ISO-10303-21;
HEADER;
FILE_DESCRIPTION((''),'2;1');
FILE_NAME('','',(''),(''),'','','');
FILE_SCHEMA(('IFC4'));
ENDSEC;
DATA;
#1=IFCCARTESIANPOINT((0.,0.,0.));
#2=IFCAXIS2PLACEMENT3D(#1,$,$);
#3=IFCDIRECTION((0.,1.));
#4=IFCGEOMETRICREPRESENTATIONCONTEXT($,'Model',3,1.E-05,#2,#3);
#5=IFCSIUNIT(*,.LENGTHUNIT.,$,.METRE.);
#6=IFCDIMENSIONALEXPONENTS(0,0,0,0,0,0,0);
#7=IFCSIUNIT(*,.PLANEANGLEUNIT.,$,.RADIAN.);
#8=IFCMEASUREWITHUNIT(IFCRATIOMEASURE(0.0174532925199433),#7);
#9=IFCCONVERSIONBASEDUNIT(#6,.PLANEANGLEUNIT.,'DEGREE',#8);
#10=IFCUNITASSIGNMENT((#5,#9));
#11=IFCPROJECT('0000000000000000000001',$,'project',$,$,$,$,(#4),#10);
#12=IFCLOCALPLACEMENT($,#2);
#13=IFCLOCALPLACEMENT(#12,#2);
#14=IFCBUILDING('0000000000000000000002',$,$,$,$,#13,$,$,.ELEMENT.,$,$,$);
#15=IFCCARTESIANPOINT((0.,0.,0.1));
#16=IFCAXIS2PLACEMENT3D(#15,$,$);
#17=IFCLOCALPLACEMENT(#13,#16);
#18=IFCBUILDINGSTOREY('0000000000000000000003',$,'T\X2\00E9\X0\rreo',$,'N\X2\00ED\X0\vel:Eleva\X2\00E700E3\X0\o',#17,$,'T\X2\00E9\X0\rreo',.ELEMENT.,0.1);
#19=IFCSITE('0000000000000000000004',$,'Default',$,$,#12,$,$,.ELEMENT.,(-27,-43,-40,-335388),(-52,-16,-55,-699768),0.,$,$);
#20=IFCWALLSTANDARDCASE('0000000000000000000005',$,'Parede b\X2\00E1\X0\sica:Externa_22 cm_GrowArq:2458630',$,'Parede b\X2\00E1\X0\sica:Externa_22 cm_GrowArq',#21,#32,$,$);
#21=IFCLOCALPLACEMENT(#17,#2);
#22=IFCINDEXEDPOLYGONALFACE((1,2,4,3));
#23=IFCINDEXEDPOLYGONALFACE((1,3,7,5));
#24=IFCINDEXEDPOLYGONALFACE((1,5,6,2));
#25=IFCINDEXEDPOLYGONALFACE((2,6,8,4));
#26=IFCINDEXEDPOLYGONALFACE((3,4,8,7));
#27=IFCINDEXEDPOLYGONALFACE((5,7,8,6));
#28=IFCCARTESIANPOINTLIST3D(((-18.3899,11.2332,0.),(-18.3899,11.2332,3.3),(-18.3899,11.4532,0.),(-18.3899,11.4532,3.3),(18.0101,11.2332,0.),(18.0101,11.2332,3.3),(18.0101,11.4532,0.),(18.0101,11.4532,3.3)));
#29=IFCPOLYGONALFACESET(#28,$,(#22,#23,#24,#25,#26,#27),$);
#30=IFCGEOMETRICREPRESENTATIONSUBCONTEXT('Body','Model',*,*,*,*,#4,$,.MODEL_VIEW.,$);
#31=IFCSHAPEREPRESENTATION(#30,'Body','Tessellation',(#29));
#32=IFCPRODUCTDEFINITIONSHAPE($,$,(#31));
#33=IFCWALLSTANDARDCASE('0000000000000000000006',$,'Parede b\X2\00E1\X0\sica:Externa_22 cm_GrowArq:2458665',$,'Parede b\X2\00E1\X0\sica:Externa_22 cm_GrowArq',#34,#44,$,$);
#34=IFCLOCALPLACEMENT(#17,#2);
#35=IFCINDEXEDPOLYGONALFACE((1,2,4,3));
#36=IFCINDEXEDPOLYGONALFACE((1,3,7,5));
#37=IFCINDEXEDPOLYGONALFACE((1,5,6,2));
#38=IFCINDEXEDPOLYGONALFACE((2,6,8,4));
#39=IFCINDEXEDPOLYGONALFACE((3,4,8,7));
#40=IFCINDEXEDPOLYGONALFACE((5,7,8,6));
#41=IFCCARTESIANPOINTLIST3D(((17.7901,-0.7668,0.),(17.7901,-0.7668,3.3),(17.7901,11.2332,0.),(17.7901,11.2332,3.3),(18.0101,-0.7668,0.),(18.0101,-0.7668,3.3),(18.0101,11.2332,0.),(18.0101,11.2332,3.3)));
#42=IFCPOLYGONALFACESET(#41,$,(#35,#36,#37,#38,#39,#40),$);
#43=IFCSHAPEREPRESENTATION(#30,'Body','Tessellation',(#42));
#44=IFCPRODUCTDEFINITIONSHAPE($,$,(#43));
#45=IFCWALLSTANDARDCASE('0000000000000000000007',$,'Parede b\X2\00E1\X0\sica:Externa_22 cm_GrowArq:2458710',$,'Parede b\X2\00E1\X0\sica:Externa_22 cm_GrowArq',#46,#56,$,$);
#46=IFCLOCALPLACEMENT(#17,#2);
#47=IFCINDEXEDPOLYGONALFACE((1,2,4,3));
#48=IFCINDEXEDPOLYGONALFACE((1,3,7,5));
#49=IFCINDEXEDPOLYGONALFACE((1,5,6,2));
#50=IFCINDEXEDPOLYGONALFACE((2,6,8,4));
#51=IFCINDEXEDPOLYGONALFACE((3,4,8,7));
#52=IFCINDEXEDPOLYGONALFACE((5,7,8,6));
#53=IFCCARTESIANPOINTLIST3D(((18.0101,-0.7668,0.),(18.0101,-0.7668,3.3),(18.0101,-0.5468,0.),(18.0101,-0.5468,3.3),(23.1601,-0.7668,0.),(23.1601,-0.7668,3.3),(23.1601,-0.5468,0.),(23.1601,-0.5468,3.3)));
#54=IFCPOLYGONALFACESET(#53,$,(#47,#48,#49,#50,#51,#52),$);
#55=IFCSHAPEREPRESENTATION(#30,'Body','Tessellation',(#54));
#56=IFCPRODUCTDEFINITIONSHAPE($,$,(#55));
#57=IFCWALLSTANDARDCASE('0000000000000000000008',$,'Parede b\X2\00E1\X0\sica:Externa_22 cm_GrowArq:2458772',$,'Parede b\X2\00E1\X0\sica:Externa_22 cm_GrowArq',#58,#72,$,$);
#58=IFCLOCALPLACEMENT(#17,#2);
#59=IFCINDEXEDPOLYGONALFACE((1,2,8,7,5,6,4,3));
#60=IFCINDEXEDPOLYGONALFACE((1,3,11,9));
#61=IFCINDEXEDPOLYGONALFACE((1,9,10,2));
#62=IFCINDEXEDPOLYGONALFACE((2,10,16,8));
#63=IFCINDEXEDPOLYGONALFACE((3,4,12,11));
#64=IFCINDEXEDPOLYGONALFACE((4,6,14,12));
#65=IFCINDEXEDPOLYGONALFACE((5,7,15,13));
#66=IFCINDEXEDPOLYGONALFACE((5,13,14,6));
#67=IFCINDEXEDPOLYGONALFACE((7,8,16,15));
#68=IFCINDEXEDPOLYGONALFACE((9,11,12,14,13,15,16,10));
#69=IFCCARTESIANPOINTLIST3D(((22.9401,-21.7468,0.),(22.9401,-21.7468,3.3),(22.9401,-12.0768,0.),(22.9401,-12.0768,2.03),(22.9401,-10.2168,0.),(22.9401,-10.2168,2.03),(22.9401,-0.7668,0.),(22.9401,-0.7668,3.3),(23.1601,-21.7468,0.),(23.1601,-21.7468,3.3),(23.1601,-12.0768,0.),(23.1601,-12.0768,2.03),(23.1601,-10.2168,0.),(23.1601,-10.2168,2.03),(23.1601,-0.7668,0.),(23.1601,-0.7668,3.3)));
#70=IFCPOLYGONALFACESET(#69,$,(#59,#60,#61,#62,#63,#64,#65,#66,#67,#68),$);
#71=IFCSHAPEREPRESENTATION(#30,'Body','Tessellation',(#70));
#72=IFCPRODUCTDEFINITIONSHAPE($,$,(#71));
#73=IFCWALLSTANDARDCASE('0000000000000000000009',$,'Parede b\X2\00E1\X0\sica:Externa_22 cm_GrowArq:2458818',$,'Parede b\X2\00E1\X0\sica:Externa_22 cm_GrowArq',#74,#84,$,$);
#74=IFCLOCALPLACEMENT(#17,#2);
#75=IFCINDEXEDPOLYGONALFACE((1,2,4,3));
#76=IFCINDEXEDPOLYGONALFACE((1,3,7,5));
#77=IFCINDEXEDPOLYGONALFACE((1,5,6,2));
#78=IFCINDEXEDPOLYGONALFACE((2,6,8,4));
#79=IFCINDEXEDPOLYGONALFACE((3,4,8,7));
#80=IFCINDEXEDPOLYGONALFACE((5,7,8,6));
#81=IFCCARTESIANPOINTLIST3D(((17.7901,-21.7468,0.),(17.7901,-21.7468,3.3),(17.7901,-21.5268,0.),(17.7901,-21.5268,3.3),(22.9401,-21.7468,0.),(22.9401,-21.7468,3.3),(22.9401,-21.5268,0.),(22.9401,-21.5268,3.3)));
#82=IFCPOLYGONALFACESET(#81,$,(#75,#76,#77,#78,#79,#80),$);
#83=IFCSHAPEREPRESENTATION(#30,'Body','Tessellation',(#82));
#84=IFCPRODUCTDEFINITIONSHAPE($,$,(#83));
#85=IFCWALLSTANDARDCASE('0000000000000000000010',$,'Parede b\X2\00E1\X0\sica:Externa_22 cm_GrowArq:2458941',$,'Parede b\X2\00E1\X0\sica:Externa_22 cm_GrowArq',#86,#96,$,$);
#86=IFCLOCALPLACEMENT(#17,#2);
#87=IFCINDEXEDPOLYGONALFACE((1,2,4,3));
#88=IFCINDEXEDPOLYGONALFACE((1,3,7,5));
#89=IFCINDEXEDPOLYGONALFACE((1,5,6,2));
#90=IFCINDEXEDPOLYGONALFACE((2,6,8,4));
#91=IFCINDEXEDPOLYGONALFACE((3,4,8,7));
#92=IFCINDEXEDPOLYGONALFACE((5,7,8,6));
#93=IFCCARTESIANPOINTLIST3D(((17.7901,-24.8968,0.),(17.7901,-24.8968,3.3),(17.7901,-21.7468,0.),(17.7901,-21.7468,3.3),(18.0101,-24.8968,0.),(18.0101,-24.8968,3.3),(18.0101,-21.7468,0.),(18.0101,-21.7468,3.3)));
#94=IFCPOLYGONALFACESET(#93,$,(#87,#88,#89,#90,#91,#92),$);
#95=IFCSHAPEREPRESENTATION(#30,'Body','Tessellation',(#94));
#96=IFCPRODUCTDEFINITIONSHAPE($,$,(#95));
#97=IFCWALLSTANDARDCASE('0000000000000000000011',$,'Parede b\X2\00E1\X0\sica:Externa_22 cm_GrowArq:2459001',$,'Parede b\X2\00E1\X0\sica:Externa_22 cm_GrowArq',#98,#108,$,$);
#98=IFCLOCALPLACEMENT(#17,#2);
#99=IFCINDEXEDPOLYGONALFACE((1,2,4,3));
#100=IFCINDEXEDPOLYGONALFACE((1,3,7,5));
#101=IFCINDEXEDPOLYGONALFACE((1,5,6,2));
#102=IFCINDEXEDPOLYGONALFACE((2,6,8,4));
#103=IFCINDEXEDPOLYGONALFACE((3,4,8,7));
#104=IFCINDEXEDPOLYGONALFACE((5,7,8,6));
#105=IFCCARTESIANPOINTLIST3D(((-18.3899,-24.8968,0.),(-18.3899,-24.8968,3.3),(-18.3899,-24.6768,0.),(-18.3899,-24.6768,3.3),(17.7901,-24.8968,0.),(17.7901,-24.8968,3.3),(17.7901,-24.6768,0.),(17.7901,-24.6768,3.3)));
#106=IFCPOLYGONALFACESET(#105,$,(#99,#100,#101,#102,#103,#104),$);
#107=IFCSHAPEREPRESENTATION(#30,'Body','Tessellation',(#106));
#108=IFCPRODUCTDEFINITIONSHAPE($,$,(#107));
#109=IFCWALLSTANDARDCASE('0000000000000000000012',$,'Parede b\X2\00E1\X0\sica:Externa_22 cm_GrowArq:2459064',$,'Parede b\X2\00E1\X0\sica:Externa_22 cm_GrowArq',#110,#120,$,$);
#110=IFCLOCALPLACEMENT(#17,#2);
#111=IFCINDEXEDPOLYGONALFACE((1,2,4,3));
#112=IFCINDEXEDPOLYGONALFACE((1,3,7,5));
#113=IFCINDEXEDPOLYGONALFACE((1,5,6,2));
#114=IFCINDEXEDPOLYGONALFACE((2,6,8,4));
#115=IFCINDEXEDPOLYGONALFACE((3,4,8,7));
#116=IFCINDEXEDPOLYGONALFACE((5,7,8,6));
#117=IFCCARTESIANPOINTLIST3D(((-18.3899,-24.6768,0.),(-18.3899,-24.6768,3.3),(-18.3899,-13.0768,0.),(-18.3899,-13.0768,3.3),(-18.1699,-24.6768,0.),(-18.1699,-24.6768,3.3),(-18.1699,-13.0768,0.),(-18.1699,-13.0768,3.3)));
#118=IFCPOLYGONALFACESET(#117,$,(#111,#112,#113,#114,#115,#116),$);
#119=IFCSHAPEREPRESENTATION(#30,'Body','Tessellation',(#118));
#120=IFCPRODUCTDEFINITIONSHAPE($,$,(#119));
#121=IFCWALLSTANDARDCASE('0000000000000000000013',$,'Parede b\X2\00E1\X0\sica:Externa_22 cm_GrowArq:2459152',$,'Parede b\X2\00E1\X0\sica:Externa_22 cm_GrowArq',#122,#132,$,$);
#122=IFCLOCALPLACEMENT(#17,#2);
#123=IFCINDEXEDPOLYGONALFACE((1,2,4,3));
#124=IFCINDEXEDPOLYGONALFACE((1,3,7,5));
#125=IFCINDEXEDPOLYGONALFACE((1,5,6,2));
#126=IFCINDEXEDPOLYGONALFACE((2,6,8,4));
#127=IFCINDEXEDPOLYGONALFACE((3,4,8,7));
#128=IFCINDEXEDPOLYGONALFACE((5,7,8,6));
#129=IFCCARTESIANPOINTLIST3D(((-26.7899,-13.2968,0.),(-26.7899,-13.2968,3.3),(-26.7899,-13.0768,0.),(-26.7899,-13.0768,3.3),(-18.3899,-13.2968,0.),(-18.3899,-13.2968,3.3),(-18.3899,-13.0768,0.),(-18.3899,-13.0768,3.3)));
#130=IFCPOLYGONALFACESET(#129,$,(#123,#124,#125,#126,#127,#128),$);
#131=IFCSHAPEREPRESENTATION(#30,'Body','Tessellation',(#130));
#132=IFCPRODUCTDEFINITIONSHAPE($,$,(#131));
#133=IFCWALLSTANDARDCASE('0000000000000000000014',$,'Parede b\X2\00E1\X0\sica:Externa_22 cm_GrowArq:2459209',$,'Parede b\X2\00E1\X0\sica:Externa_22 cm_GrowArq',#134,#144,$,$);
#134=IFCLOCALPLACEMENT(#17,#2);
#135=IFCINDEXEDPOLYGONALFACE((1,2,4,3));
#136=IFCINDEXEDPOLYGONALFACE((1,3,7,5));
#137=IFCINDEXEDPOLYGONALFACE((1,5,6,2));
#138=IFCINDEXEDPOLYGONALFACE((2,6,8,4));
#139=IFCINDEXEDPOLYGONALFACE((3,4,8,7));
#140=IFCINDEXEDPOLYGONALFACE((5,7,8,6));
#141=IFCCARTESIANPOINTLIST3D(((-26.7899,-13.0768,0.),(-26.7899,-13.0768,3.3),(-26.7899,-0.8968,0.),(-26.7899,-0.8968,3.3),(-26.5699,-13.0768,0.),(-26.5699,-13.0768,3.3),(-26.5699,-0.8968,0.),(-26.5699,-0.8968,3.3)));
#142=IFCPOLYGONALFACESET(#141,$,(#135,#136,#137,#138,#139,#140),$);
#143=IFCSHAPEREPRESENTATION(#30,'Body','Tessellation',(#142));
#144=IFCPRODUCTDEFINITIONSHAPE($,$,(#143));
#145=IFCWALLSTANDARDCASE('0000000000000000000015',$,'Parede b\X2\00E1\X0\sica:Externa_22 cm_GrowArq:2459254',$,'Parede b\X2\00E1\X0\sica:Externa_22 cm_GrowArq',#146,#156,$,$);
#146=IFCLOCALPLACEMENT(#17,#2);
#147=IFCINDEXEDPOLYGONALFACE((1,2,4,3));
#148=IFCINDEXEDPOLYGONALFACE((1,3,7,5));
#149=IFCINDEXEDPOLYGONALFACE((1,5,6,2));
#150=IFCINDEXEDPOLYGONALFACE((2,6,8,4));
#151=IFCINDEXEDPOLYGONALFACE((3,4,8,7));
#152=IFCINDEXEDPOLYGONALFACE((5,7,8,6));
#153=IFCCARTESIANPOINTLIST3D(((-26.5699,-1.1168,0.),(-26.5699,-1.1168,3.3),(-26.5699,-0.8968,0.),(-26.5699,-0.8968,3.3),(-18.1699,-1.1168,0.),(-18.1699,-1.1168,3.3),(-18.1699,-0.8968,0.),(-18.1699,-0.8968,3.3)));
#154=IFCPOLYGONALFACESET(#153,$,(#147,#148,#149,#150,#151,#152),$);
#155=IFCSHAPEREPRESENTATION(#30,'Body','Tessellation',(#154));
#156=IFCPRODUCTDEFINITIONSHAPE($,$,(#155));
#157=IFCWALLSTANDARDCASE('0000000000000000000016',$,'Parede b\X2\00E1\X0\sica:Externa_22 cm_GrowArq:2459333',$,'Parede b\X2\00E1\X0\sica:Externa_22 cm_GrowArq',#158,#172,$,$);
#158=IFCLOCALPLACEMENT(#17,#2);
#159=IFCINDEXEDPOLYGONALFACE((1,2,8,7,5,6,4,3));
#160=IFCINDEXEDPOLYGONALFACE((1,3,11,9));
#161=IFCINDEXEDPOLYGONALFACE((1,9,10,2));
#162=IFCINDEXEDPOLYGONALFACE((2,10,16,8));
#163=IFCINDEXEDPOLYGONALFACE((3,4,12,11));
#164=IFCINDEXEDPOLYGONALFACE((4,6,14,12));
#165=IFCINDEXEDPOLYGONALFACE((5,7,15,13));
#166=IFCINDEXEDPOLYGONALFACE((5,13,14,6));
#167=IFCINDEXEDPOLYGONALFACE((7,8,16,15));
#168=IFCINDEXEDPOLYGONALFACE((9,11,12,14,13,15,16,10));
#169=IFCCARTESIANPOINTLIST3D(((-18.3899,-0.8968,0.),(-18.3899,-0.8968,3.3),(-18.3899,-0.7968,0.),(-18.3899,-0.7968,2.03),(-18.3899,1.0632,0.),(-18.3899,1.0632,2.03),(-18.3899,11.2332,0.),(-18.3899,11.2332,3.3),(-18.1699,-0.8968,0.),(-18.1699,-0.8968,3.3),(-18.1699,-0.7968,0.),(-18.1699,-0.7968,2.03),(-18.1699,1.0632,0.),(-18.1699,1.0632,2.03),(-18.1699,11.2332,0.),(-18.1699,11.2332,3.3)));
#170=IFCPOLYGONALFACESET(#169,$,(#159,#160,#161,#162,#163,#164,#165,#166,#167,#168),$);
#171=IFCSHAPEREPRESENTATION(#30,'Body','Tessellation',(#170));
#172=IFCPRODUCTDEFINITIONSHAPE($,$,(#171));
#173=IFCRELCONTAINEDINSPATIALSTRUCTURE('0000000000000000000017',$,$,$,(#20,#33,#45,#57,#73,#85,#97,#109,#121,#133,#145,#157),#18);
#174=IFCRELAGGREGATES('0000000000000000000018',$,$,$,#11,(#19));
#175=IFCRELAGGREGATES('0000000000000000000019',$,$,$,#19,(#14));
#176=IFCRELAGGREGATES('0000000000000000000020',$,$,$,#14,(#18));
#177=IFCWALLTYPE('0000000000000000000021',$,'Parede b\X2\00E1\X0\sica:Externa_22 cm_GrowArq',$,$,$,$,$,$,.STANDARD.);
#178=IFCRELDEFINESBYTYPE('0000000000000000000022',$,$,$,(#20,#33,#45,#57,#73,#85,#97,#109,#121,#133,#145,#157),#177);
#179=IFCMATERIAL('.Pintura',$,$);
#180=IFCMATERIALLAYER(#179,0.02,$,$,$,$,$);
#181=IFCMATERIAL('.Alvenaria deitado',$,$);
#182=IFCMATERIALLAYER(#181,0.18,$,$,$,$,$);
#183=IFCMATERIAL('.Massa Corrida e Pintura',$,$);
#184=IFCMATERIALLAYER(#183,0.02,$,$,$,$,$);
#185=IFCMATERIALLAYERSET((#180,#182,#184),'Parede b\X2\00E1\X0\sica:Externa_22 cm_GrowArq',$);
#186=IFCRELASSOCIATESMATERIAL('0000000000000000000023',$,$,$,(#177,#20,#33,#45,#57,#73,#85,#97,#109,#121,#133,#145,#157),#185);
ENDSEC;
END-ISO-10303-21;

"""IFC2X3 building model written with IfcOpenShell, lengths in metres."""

from ifc_helpers import new_model, entity, si_unit, converted_unit, direction, frame, frame_2d, origin, place, context, subcontext, project, spatial, rectangle, extrude, material, layer, layer_set, layer_usage, type_object, element, save


model = new_model("IFC2X3")

# Units and contexts
model_context = context("Model", 3, precision=1e-05, world=origin(), true_north=direction((0.0, 1.0)))
body_context = subcontext(model_context, "Body", "Model", "MODEL_VIEW")
ifc_project = project(units=[si_unit("LENGTHUNIT", "METRE"), converted_unit("PLANEANGLEUNIT", "DEGREE", entity("IfcRatioMeasure", 0.0174532925199433), si_unit("PLANEANGLEUNIT", "RADIAN"), dimensions=[0, 0, 0, 0, 0, 0, 0])], contexts=[model_context])

# Site, building, storey
site_placement = place(None, origin())
site = spatial("IfcSite", under=ifc_project, at=site_placement, Name="Default", CompositionType="ELEMENT", RefLatitude=(-27, -43, -40, -335388), RefLongitude=(-52, -16, -55, -699768), RefElevation=0.0)
building_placement = place(site_placement, origin())
building = spatial("IfcBuilding", under=site, at=building_placement, CompositionType="ELEMENT")
storey_placement = place(building_placement, frame((0.0, 0.0, 0.1)))
storey = spatial("IfcBuildingStorey", under=building, at=storey_placement, Name="Térreo", ObjectType="Nível:Elevação", LongName="Térreo", CompositionType="ELEMENT", Elevation=0.1)

# Walls
ifc_material_1 = material(Name=".Pintura")
ifc_layer_1 = layer(ifc_material_1, 0.02)
ifc_material_2 = material(Name=".Alvenaria deitado")
ifc_layer_2 = layer(ifc_material_2, 0.18)
ifc_material_3 = material(Name=".Massa Corrida e Pintura")
ifc_layer_3 = layer(ifc_material_3, 0.02)
ifc_layer_set_1 = layer_set([ifc_layer_1, ifc_layer_2, ifc_layer_3], Name="Parede básica:Externa_22 cm_GrowArq")
ifc_layer_usage_1 = layer_usage(ifc_layer_set_1, "AXIS2", "NEGATIVE", 0.11)
wall_type = type_object("IfcWallType", Name="Parede básica:Externa_22 cm_GrowArq", PredefinedType="STANDARD", material=ifc_layer_set_1)
wall_1_placement = place(storey_placement, frame((-18.3899, 11.3432, 0.0)))
element("IfcWallStandardCase", 1, at=wall_1_placement, inside=storey, type_object=wall_type, material=ifc_layer_usage_1, Name="Parede básica:Externa_22 cm_GrowArq:2458630", ObjectType="Parede básica:Externa_22 cm_GrowArq", context=body_context, shape_type="SweptSolid", body=[
    extrude(rectangle(XDim=36.4, YDim=0.22, at=frame_2d((18.2, 0.0), x_axis=(-1.0, 0.0))), origin(), (0.0, 0.0, 1.0), 3.3),
])
ifc_layer_usage_2 = layer_usage(ifc_layer_set_1, "AXIS2", "NEGATIVE", 0.11)
wall_2_placement = place(storey_placement, frame((17.9001, 11.2332, 0.0), z_axis=(0.0, 0.0, 1.0), x_axis=(0.0, -1.0, 0.0)))
element("IfcWallStandardCase", 2, at=wall_2_placement, inside=storey, type_object=wall_type, material=ifc_layer_usage_2, Name="Parede básica:Externa_22 cm_GrowArq:2458665", ObjectType="Parede básica:Externa_22 cm_GrowArq", context=body_context, shape_type="SweptSolid", body=[
    extrude(rectangle(XDim=12.0, YDim=0.22, at=frame_2d((6.0, 0.0), x_axis=(-1.0, 0.0))), origin(), (0.0, 0.0, 1.0), 3.3),
])
ifc_layer_usage_3 = layer_usage(ifc_layer_set_1, "AXIS2", "NEGATIVE", 0.11)
wall_3_placement = place(storey_placement, frame((18.0101, -0.6568, 0.0)))
element("IfcWallStandardCase", 3, at=wall_3_placement, inside=storey, type_object=wall_type, material=ifc_layer_usage_3, Name="Parede básica:Externa_22 cm_GrowArq:2458710", ObjectType="Parede básica:Externa_22 cm_GrowArq", context=body_context, shape_type="SweptSolid", body=[
    extrude(rectangle(XDim=5.15, YDim=0.22, at=frame_2d((2.575, 0.0), x_axis=(-1.0, 0.0))), origin(), (0.0, 0.0, 1.0), 3.3),
])

# Wall, opening
ifc_layer_usage_4 = layer_usage(ifc_layer_set_1, "AXIS2", "NEGATIVE", 0.11)
wall_4_placement = place(storey_placement, frame((23.0501, -0.7668, 0.0), z_axis=(0.0, 0.0, 1.0), x_axis=(0.0, -1.0, 0.0)))
wall_4 = element("IfcWallStandardCase", 4, at=wall_4_placement, inside=storey, type_object=wall_type, material=ifc_layer_usage_4, Name="Parede básica:Externa_22 cm_GrowArq:2458772", ObjectType="Parede básica:Externa_22 cm_GrowArq", context=body_context, shape_type="SweptSolid", body=[
    extrude(rectangle(XDim=20.98, YDim=0.22, at=frame_2d((10.49, 0.0), x_axis=(-1.0, 0.0))), origin(), (0.0, 0.0, 1.0), 3.3),
])
opening_1_placement = place(wall_4_placement, frame((9.45, -0.11, -0.1)))
element("IfcOpeningElement", 5, at=opening_1_placement, cuts=wall_4, ObjectType="Opening", context=body_context, shape_type="SweptSolid", body=[
    extrude(rectangle(XDim=2.13, YDim=1.86, at=frame_2d((1.065, 0.93), x_axis=(1.0, 0.0))), frame((0.0, 0.0, 0.0), z_axis=(0.0, 1.0, 0.0), x_axis=(0.0, 0.0, 1.0)), (0.0, 0.0, 1.0), 0.22),
])

# Walls
ifc_layer_usage_5 = layer_usage(ifc_layer_set_1, "AXIS2", "NEGATIVE", 0.11)
wall_5_placement = place(storey_placement, frame((22.9401, -21.6368, 0.0), z_axis=(0.0, 0.0, 1.0), x_axis=(-1.0, 0.0, 0.0)))
element("IfcWallStandardCase", 6, at=wall_5_placement, inside=storey, type_object=wall_type, material=ifc_layer_usage_5, Name="Parede básica:Externa_22 cm_GrowArq:2458818", ObjectType="Parede básica:Externa_22 cm_GrowArq", context=body_context, shape_type="SweptSolid", body=[
    extrude(rectangle(XDim=5.15, YDim=0.22, at=frame_2d((2.575, 0.0), x_axis=(-1.0, 0.0))), origin(), (0.0, 0.0, 1.0), 3.3),
])
ifc_layer_usage_6 = layer_usage(ifc_layer_set_1, "AXIS2", "NEGATIVE", 0.11)
wall_6_placement = place(storey_placement, frame((17.9001, -21.7468, 0.0), z_axis=(0.0, 0.0, 1.0), x_axis=(0.0, -1.0, 0.0)))
element("IfcWallStandardCase", 7, at=wall_6_placement, inside=storey, type_object=wall_type, material=ifc_layer_usage_6, Name="Parede básica:Externa_22 cm_GrowArq:2458941", ObjectType="Parede básica:Externa_22 cm_GrowArq", context=body_context, shape_type="SweptSolid", body=[
    extrude(rectangle(XDim=3.15, YDim=0.22, at=frame_2d((1.575, 0.0), x_axis=(-1.0, 0.0))), origin(), (0.0, 0.0, 1.0), 3.3),
])
ifc_layer_usage_7 = layer_usage(ifc_layer_set_1, "AXIS2", "NEGATIVE", 0.11)
wall_7_placement = place(storey_placement, frame((17.7901, -24.7868, 0.0), z_axis=(0.0, 0.0, 1.0), x_axis=(-1.0, 0.0, 0.0)))
element("IfcWallStandardCase", 8, at=wall_7_placement, inside=storey, type_object=wall_type, material=ifc_layer_usage_7, Name="Parede básica:Externa_22 cm_GrowArq:2459001", ObjectType="Parede básica:Externa_22 cm_GrowArq", context=body_context, shape_type="SweptSolid", body=[
    extrude(rectangle(XDim=36.18, YDim=0.22, at=frame_2d((18.09, 0.0), x_axis=(-1.0, 0.0))), origin(), (0.0, 0.0, 1.0), 3.3),
])
ifc_layer_usage_8 = layer_usage(ifc_layer_set_1, "AXIS2", "NEGATIVE", 0.11)
wall_8_placement = place(storey_placement, frame((-18.2799, -24.6768, 0.0), z_axis=(0.0, 0.0, 1.0), x_axis=(0.0, 1.0, 0.0)))
element("IfcWallStandardCase", 9, at=wall_8_placement, inside=storey, type_object=wall_type, material=ifc_layer_usage_8, Name="Parede básica:Externa_22 cm_GrowArq:2459064", ObjectType="Parede básica:Externa_22 cm_GrowArq", context=body_context, shape_type="SweptSolid", body=[
    extrude(rectangle(XDim=11.6, YDim=0.22, at=frame_2d((5.8, 0.0), x_axis=(-1.0, 0.0))), origin(), (0.0, 0.0, 1.0), 3.3),
])
ifc_layer_usage_9 = layer_usage(ifc_layer_set_1, "AXIS2", "NEGATIVE", 0.11)
wall_9_placement = place(storey_placement, frame((-18.3899, -13.1868, 0.0), z_axis=(0.0, 0.0, 1.0), x_axis=(-1.0, 0.0, 0.0)))
element("IfcWallStandardCase", 10, at=wall_9_placement, inside=storey, type_object=wall_type, material=ifc_layer_usage_9, Name="Parede básica:Externa_22 cm_GrowArq:2459152", ObjectType="Parede básica:Externa_22 cm_GrowArq", context=body_context, shape_type="SweptSolid", body=[
    extrude(rectangle(XDim=8.4, YDim=0.22, at=frame_2d((4.2, 0.0), x_axis=(-1.0, 0.0))), origin(), (0.0, 0.0, 1.0), 3.3),
])
ifc_layer_usage_10 = layer_usage(ifc_layer_set_1, "AXIS2", "NEGATIVE", 0.11)
wall_10_placement = place(storey_placement, frame((-26.6799, -13.0768, 0.0), z_axis=(0.0, 0.0, 1.0), x_axis=(0.0, 1.0, 0.0)))
element("IfcWallStandardCase", 11, at=wall_10_placement, inside=storey, type_object=wall_type, material=ifc_layer_usage_10, Name="Parede básica:Externa_22 cm_GrowArq:2459209", ObjectType="Parede básica:Externa_22 cm_GrowArq", context=body_context, shape_type="SweptSolid", body=[
    extrude(rectangle(XDim=12.18, YDim=0.22, at=frame_2d((6.09, 0.0), x_axis=(-1.0, 0.0))), origin(), (0.0, 0.0, 1.0), 3.3),
])
ifc_layer_usage_11 = layer_usage(ifc_layer_set_1, "AXIS2", "NEGATIVE", 0.11)
wall_11_placement = place(storey_placement, frame((-26.5699, -1.0068, 0.0)))
element("IfcWallStandardCase", 12, at=wall_11_placement, inside=storey, type_object=wall_type, material=ifc_layer_usage_11, Name="Parede básica:Externa_22 cm_GrowArq:2459254", ObjectType="Parede básica:Externa_22 cm_GrowArq", context=body_context, shape_type="SweptSolid", body=[
    extrude(rectangle(XDim=8.4, YDim=0.22, at=frame_2d((4.2, 0.0), x_axis=(-1.0, 0.0))), origin(), (0.0, 0.0, 1.0), 3.3),
])

# Wall, opening
ifc_layer_usage_12 = layer_usage(ifc_layer_set_1, "AXIS2", "NEGATIVE", 0.11)
wall_12_placement = place(storey_placement, frame((-18.2799, -0.8968, 0.0), z_axis=(0.0, 0.0, 1.0), x_axis=(0.0, 1.0, 0.0)))
wall_12 = element("IfcWallStandardCase", 13, at=wall_12_placement, inside=storey, type_object=wall_type, material=ifc_layer_usage_12, Name="Parede básica:Externa_22 cm_GrowArq:2459333", ObjectType="Parede básica:Externa_22 cm_GrowArq", context=body_context, shape_type="SweptSolid", body=[
    extrude(rectangle(XDim=12.13, YDim=0.22, at=frame_2d((6.065, 0.0), x_axis=(-1.0, 0.0))), origin(), (0.0, 0.0, 1.0), 3.3),
])
opening_2_placement = place(wall_12_placement, frame((0.1, -0.11, -0.1)))
element("IfcOpeningElement", 14, at=opening_2_placement, cuts=wall_12, ObjectType="Opening", context=body_context, shape_type="SweptSolid", body=[
    extrude(rectangle(XDim=2.13, YDim=1.86, at=frame_2d((1.065, 0.93), x_axis=(1.0, 0.0))), frame((0.0, 0.0, 0.0), z_axis=(0.0, 1.0, 0.0), x_axis=(0.0, 0.0, 1.0)), (0.0, 0.0, 1.0), 0.22),
])

save(model, "model.ifc")
